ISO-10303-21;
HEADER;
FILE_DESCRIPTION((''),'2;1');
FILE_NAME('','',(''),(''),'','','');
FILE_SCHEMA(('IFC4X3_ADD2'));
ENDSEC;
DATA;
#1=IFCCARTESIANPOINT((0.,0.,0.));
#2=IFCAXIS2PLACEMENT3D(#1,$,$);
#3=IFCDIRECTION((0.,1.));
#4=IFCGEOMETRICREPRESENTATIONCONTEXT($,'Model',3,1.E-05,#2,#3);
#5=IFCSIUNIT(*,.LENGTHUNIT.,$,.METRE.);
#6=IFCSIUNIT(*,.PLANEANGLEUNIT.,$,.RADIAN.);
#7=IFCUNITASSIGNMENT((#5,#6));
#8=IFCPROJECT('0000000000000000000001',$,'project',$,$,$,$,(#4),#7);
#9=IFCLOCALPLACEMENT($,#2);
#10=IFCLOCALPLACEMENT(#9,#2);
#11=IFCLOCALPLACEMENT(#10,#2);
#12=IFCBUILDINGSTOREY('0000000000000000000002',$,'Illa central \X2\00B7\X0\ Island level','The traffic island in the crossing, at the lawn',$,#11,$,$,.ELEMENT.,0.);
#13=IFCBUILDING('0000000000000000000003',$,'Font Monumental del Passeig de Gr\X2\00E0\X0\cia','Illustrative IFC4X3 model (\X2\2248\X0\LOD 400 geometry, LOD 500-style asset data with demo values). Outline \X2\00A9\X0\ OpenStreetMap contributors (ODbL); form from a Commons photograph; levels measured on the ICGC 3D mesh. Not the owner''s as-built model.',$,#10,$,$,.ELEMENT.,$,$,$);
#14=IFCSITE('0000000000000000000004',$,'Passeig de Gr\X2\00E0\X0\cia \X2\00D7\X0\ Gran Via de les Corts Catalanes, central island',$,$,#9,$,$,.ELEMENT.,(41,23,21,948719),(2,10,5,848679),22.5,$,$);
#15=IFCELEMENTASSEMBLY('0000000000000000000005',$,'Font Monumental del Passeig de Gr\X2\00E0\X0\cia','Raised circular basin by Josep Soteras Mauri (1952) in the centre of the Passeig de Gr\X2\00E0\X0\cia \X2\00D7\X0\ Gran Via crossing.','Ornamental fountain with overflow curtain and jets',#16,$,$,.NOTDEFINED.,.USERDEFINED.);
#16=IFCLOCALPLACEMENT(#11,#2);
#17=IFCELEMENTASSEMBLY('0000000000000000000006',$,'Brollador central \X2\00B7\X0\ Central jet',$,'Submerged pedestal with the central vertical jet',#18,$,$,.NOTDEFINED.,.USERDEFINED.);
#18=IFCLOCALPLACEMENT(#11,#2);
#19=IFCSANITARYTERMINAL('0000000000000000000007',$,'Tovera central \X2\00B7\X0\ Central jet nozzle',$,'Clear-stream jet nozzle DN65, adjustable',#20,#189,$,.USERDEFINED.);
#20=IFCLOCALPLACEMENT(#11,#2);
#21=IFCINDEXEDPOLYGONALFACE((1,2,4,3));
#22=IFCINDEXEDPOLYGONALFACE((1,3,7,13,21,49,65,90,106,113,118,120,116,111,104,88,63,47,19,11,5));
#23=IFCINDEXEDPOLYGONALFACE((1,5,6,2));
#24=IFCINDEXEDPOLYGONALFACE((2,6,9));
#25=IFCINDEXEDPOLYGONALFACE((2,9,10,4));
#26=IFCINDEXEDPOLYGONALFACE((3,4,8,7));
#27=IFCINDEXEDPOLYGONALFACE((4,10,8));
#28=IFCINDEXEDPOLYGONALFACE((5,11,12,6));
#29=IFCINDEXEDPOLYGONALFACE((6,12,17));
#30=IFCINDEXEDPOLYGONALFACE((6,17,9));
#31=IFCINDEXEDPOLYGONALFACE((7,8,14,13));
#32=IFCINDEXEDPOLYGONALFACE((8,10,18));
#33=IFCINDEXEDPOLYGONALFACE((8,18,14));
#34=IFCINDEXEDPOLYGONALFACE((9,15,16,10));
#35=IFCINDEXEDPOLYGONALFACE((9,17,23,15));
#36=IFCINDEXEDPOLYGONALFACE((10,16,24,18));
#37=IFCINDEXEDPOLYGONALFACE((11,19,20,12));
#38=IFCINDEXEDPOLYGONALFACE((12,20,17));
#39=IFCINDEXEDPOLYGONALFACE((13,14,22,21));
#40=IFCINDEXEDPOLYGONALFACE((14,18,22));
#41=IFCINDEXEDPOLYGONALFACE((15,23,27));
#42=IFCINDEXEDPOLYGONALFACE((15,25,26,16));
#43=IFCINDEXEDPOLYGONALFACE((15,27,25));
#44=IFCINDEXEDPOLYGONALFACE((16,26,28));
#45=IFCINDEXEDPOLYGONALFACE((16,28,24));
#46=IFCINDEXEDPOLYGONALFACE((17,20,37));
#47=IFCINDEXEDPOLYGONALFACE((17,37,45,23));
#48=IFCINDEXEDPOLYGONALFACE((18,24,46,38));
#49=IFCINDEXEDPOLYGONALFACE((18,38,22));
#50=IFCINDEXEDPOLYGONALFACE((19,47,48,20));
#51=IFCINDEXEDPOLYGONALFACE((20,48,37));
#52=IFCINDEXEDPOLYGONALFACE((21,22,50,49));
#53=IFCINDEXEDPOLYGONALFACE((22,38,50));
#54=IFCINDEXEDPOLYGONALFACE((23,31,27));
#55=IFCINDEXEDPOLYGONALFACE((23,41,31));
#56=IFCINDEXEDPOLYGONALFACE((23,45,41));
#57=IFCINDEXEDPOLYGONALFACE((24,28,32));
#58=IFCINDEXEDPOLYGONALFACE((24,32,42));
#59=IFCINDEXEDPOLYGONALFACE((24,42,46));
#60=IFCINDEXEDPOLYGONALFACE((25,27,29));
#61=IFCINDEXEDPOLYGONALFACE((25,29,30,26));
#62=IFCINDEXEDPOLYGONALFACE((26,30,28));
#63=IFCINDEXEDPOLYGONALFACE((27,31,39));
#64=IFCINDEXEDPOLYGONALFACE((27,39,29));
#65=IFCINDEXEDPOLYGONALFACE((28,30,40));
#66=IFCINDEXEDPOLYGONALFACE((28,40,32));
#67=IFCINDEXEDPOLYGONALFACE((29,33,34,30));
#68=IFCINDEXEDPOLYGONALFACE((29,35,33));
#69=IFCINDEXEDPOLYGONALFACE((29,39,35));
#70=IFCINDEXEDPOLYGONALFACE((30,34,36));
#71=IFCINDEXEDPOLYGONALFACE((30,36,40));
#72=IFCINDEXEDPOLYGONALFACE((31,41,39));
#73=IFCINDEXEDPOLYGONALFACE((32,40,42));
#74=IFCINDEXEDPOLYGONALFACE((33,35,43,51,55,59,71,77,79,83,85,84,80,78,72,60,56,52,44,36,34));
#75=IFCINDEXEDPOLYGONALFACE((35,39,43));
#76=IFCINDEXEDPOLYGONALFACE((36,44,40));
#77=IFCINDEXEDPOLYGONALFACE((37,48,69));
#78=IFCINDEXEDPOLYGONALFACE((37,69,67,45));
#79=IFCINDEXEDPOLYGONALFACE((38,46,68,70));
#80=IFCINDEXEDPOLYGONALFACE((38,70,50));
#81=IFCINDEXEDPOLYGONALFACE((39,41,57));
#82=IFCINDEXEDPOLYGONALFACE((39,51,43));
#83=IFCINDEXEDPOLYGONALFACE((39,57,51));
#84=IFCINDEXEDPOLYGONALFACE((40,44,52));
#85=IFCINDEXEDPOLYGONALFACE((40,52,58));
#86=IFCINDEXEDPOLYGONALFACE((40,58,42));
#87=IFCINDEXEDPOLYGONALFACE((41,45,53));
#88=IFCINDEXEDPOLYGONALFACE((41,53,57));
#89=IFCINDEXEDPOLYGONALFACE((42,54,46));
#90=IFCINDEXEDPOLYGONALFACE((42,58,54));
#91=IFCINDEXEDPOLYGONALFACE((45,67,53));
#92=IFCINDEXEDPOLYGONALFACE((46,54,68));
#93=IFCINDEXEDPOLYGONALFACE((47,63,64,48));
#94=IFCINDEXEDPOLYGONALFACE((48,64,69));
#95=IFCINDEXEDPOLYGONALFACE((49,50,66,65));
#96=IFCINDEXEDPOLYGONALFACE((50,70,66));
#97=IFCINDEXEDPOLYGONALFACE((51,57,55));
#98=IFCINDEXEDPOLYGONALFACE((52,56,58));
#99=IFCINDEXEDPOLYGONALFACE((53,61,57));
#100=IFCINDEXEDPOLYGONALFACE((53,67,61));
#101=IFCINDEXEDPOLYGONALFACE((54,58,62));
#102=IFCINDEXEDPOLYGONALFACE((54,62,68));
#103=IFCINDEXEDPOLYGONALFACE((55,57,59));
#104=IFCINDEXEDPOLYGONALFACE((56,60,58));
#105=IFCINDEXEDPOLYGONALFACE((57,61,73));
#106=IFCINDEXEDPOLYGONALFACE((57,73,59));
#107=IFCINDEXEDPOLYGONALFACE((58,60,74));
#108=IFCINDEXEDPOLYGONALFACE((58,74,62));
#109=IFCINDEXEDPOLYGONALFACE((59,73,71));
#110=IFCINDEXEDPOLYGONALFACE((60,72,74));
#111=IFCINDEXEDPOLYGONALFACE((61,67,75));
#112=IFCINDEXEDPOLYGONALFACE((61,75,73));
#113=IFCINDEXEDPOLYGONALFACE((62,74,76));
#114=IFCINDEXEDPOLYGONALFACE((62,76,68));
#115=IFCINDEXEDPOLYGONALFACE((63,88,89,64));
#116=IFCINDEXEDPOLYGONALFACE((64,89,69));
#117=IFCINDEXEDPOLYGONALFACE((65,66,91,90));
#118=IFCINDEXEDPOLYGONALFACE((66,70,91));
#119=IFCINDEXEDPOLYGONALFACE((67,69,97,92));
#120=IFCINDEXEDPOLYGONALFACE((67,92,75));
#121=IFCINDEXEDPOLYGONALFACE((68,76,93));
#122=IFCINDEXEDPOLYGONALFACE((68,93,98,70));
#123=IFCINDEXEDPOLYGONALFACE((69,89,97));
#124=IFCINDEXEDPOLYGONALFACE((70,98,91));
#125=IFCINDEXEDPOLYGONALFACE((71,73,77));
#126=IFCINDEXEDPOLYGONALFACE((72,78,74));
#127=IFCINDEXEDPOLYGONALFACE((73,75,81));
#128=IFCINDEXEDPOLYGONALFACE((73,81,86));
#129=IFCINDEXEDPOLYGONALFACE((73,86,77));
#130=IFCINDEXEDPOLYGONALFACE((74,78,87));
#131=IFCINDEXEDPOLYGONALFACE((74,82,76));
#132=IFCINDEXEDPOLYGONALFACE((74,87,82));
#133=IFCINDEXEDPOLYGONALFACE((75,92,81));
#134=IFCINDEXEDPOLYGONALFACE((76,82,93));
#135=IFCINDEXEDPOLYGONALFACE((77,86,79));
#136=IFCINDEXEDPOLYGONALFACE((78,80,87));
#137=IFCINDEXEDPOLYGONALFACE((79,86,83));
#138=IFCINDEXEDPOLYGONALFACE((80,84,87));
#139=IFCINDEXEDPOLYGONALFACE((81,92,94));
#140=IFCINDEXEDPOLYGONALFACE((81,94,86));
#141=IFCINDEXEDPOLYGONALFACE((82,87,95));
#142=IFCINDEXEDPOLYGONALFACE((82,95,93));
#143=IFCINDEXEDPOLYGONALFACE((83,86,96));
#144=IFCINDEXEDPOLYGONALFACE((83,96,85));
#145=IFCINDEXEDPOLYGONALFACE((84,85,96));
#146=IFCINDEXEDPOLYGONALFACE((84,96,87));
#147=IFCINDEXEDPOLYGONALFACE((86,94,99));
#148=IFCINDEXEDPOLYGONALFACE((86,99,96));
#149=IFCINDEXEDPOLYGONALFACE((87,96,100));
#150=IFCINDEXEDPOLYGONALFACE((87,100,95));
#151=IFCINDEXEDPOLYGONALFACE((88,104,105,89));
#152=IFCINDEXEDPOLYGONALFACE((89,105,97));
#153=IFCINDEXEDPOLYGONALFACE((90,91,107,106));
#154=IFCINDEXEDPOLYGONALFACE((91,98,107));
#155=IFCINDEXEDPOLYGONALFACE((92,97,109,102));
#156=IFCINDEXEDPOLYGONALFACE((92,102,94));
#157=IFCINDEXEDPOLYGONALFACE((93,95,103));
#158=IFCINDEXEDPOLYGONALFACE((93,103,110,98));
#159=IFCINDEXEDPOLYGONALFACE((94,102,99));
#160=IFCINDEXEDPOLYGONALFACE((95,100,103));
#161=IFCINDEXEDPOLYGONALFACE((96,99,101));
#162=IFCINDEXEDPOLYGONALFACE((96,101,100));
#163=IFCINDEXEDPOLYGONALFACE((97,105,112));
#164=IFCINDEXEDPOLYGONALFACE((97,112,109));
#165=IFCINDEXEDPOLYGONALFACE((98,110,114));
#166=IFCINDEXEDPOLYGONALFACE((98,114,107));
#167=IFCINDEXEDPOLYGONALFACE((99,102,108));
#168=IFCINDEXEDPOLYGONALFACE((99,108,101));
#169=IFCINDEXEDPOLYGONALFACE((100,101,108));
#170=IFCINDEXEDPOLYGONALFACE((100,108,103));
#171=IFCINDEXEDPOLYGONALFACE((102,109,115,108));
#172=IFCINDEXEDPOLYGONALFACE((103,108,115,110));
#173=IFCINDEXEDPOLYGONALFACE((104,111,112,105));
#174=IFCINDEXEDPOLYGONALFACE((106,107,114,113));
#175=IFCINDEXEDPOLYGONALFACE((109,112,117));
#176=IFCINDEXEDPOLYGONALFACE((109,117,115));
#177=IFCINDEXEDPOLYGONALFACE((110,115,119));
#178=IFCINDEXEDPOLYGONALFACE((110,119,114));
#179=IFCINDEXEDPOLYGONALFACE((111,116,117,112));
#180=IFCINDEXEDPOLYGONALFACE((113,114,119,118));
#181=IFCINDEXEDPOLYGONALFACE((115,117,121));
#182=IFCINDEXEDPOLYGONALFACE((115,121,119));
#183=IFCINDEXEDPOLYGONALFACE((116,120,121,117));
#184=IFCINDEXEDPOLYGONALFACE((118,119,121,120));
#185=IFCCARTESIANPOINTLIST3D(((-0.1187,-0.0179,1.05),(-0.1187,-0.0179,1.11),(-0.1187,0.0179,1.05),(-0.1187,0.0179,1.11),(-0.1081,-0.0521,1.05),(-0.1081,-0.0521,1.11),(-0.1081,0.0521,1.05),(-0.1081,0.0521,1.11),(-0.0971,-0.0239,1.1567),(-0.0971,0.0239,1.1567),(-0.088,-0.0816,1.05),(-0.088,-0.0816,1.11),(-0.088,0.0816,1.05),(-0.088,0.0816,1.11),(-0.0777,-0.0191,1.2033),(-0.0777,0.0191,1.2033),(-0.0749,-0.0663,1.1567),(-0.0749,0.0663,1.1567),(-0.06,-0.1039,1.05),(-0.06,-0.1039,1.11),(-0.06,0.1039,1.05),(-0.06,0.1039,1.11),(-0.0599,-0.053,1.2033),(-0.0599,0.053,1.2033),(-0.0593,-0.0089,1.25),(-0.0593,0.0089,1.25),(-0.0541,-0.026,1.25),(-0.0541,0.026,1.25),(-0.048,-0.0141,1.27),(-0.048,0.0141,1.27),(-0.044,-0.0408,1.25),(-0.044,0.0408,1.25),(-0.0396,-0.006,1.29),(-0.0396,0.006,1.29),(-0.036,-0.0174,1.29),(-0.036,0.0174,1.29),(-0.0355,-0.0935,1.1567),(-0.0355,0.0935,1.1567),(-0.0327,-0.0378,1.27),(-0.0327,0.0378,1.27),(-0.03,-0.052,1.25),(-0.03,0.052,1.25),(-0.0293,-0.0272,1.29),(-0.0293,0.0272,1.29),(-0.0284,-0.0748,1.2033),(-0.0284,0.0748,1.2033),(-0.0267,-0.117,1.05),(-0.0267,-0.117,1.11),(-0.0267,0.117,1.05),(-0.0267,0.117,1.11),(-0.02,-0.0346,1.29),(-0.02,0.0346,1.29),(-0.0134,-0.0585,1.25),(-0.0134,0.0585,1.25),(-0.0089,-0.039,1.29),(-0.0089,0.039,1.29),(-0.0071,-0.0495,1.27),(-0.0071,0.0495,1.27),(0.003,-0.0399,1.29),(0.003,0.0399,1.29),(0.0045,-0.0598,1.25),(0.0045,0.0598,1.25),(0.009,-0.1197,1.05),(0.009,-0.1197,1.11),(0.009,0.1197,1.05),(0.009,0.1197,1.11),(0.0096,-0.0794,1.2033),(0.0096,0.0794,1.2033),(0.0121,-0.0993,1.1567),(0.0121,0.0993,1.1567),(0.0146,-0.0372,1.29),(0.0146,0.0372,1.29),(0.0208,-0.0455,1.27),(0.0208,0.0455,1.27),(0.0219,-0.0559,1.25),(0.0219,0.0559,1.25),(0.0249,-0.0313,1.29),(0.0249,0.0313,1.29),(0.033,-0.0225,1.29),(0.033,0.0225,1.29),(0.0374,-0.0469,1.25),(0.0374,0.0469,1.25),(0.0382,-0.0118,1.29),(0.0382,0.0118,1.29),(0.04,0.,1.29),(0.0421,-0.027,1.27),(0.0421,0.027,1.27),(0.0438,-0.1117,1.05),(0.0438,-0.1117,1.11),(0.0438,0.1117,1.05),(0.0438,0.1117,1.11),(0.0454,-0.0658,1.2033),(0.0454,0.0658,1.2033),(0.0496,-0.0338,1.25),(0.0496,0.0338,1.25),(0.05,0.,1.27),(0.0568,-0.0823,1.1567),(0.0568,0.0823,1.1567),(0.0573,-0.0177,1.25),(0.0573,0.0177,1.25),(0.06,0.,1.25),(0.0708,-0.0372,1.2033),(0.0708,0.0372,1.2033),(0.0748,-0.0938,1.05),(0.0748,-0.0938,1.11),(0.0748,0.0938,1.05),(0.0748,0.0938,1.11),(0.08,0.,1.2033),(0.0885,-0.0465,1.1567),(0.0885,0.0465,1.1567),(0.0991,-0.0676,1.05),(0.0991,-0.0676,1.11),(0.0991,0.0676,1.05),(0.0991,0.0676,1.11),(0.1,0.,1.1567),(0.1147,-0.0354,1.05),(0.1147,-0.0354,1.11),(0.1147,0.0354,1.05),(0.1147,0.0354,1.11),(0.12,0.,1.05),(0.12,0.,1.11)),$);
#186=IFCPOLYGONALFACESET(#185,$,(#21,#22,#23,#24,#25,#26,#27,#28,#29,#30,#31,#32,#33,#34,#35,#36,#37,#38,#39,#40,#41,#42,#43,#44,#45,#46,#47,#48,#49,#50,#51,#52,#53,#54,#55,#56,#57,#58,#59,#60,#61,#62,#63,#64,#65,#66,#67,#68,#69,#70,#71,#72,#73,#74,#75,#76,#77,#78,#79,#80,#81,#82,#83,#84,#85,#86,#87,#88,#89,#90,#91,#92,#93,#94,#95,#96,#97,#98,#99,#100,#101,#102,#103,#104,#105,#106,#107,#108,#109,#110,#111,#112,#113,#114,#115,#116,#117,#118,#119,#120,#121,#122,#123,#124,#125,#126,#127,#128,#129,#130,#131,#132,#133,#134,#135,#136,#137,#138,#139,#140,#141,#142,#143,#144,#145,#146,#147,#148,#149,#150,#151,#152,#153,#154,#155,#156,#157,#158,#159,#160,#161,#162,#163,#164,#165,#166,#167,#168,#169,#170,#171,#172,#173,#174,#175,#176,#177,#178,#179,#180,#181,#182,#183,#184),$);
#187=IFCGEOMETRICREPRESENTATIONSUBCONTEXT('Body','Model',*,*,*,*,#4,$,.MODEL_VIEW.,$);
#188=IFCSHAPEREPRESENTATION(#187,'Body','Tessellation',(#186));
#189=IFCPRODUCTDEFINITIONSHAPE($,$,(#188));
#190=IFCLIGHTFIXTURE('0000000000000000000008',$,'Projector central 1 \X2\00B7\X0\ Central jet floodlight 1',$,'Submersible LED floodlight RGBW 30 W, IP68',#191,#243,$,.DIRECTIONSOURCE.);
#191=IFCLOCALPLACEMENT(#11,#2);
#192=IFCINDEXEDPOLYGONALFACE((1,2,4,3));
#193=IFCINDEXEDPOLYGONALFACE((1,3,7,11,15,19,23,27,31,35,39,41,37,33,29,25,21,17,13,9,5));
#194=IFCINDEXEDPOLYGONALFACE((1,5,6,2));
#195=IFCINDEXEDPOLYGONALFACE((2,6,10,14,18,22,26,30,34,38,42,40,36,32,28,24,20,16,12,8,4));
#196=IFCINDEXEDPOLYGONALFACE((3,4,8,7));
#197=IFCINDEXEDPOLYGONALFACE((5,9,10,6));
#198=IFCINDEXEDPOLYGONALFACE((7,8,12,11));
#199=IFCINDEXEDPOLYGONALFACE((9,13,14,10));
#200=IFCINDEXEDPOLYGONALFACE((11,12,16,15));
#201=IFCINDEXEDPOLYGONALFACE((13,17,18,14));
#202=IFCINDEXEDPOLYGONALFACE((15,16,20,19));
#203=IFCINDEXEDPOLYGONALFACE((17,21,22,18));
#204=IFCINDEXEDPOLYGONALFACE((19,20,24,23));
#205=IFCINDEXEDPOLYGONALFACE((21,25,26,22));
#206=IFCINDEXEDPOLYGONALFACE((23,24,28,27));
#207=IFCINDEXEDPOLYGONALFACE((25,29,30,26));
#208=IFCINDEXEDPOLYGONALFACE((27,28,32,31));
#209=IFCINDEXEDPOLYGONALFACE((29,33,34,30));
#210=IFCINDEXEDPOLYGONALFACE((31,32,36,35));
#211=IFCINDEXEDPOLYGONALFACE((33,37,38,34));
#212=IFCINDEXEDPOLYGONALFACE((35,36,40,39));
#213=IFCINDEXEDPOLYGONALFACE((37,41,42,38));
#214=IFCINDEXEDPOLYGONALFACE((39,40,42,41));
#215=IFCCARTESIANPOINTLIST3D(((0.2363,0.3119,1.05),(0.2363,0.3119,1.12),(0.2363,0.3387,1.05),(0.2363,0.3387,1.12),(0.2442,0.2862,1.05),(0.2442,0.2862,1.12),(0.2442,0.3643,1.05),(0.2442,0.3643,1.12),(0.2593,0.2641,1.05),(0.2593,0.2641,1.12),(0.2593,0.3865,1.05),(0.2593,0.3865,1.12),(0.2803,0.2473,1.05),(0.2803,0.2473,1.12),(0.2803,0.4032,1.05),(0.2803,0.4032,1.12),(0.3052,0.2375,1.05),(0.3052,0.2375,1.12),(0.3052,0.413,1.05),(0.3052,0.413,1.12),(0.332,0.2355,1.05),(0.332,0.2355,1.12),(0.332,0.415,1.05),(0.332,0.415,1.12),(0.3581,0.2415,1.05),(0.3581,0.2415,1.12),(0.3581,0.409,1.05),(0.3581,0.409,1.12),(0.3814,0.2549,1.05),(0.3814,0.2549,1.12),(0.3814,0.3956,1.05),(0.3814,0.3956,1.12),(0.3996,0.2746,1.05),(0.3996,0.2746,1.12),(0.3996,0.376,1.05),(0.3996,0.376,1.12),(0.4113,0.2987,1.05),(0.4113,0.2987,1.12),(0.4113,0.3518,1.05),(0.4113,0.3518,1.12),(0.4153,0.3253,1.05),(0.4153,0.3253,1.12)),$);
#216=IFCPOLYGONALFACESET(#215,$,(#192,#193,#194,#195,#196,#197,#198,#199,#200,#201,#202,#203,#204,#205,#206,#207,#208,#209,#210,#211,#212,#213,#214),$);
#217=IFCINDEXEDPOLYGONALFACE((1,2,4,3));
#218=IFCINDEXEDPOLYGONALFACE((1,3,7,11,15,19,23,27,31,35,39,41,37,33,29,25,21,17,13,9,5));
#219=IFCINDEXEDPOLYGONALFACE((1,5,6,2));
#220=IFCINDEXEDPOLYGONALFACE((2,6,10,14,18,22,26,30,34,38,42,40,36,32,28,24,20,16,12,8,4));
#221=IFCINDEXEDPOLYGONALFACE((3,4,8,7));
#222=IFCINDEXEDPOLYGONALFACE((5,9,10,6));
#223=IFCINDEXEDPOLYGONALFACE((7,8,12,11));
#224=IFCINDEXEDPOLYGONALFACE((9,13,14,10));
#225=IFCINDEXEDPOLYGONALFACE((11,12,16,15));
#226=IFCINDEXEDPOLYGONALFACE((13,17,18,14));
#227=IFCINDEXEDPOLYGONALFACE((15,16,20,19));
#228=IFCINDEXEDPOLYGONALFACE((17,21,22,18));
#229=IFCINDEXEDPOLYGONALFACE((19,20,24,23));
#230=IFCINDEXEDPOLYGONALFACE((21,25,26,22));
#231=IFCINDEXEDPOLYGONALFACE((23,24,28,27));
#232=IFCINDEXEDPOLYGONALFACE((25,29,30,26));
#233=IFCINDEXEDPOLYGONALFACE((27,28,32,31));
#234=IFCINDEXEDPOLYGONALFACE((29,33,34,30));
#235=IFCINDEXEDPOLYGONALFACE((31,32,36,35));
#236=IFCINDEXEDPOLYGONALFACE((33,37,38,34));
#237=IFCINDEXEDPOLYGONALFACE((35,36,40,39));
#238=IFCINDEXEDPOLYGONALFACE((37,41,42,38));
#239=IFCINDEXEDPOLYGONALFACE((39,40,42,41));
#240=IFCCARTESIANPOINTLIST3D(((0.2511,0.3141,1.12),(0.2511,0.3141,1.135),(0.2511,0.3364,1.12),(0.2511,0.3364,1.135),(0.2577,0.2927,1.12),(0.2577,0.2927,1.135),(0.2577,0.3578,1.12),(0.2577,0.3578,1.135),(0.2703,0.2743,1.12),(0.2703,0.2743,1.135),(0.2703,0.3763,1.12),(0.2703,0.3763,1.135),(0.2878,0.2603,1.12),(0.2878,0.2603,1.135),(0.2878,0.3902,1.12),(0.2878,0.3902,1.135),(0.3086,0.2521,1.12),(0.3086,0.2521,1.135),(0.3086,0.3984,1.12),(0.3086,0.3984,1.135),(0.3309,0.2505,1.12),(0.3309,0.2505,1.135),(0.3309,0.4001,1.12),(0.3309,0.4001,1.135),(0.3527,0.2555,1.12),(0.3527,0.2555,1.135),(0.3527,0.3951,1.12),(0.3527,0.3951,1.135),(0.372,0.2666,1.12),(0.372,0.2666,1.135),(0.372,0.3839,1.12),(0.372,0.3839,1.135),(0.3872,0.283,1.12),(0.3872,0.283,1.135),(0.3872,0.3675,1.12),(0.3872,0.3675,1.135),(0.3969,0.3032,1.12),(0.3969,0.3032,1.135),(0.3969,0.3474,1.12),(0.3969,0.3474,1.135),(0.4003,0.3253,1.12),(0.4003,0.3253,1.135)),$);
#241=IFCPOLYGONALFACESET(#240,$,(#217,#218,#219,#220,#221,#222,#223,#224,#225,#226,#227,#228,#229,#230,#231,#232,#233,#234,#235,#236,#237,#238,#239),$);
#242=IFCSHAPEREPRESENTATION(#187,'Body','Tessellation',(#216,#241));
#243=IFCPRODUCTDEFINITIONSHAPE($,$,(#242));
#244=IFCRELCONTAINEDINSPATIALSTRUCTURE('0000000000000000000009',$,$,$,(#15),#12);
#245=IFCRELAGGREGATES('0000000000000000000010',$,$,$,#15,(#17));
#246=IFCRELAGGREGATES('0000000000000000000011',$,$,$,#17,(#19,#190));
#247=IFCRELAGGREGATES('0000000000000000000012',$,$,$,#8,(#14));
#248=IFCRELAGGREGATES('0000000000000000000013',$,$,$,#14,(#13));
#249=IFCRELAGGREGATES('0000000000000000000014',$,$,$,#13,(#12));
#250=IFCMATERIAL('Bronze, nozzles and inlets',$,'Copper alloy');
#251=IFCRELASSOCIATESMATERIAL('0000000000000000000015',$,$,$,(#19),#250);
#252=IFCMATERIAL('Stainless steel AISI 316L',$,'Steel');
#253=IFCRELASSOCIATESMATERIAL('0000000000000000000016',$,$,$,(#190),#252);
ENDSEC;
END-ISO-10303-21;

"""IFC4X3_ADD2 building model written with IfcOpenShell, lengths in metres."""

from ifc_helpers import new_model, entity, si_unit, direction, frame, origin, origin_2d_with_axis, place, context, subcontext, project, spatial, circle, extrude, material, element, aggregate, save


model = new_model("IFC4X3_ADD2")

# Units and contexts
model_context = context("Model", 3, precision=1e-05, world=origin(), true_north=direction((0.0, 1.0)))
body_context = subcontext(model_context, "Body", "Model", "MODEL_VIEW")
ifc_project = project(units=[si_unit("LENGTHUNIT", "METRE"), si_unit("PLANEANGLEUNIT", "RADIAN")], contexts=[model_context])

# Site, building, storey
site_placement = place(None, origin())
site = spatial("IfcSite", under=ifc_project, at=site_placement, Name="Passeig de Gràcia × Gran Via de les Corts Catalanes, central island", CompositionType="ELEMENT", RefLatitude=(41, 23, 21, 948719), RefLongitude=(2, 10, 5, 848679), RefElevation=22.5)
building_placement = place(site_placement, origin())
building = spatial("IfcBuilding", under=site, at=building_placement, Name="Font Monumental del Passeig de Gràcia", Description="Illustrative IFC4X3 model (≈LOD 400 geometry, LOD 500-style asset data with demo values). Outline © OpenStreetMap contributors (ODbL); form from a Commons photograph; levels measured on the ICGC 3D mesh. Not the owner's as-built model.", CompositionType="ELEMENT")
storey_placement = place(building_placement, origin())
storey = spatial("IfcBuildingStorey", under=building, at=storey_placement, Name="Illa central · Island level", Description="The traffic island in the crossing, at the lawn", CompositionType="ELEMENT", Elevation=0.0)

# Element assemblies, sanitary terminal, light fixture
assembly_1_placement = place(building_placement, origin())
assembly_1 = element("IfcElementAssembly", 1, at=assembly_1_placement, inside=storey, Name="Font Monumental del Passeig de Gràcia", Description="Raised circular basin by Josep Soteras Mauri (1952) in the centre of the Passeig de Gràcia × Gran Via crossing.", ObjectType="Ornamental fountain with overflow curtain and jets", AssemblyPlace="NOTDEFINED", PredefinedType="USERDEFINED")
assembly_2_placement = place(building_placement, origin())
assembly_2 = element("IfcElementAssembly", 2, at=assembly_2_placement, Name="Brollador central · Central jet", ObjectType="Submerged pedestal with the central vertical jet", AssemblyPlace="NOTDEFINED", PredefinedType="USERDEFINED")
ifc_material_1 = material(Name="Bronze, nozzles and inlets", Category="Copper alloy")
sanitary_terminal_1_placement = place(building_placement, origin())
sanitary_terminal_1 = element("IfcSanitaryTerminal", 3, at=sanitary_terminal_1_placement, material=ifc_material_1, Name="Tovera central · Central jet nozzle", ObjectType="Clear-stream jet nozzle DN65, adjustable", PredefinedType="USERDEFINED", context=body_context, shape_type="SweptSolid", body=[
    entity("IfcRevolvedAreaSolid", entity("IfcArbitraryClosedProfileDef", "AREA", None, entity("IfcPolyline", [entity("IfcCartesianPoint", [0.0, 0.0]), entity("IfcCartesianPoint", [0.12, 0.0]), entity("IfcCartesianPoint", [0.12, 0.06]), entity("IfcCartesianPoint", [0.06, 0.2]), entity("IfcCartesianPoint", [0.04, 0.24]), entity("IfcCartesianPoint", [0.0, 0.24]), entity("IfcCartesianPoint", [0.0, 0.0])])), entity("IfcAxis2Placement3D", entity("IfcCartesianPoint", [0.0, 0.0, 1.05]), entity("IfcDirection", [0.0, -1.0, 0.0]), entity("IfcDirection", [1.0, 0.0, 0.0])), entity("IfcAxis1Placement", entity("IfcCartesianPoint", [0.0, 0.0, 0.0]), entity("IfcDirection", [0.0, 1.0, 0.0])), 6.283185),
])
ifc_material_2 = material(Name="Stainless steel AISI 316L", Category="Steel")
light_fixture_1_placement = place(building_placement, origin())
light_fixture_1 = element("IfcLightFixture", 4, at=light_fixture_1_placement, material=ifc_material_2, Name="Projector central 1 · Central jet floodlight 1", ObjectType="Submersible LED floodlight RGBW 30 W, IP68", PredefinedType="DIRECTIONSOURCE", context=body_context, shape_type="SweptSolid", body=[
    extrude(circle(Radius=0.09, at=origin_2d_with_axis()), frame((0.3253, 0.3253, 1.05)), (0.0, 0.0, 1.0), 0.07),
    extrude(circle(Radius=0.075, at=origin_2d_with_axis()), frame((0.3253, 0.3253, 1.12)), (0.0, 0.0, 1.0), 0.015),
])
aggregate(assembly_1, [assembly_2])
aggregate(assembly_2, [sanitary_terminal_1, light_fixture_1])

save(model, "model.ifc")
